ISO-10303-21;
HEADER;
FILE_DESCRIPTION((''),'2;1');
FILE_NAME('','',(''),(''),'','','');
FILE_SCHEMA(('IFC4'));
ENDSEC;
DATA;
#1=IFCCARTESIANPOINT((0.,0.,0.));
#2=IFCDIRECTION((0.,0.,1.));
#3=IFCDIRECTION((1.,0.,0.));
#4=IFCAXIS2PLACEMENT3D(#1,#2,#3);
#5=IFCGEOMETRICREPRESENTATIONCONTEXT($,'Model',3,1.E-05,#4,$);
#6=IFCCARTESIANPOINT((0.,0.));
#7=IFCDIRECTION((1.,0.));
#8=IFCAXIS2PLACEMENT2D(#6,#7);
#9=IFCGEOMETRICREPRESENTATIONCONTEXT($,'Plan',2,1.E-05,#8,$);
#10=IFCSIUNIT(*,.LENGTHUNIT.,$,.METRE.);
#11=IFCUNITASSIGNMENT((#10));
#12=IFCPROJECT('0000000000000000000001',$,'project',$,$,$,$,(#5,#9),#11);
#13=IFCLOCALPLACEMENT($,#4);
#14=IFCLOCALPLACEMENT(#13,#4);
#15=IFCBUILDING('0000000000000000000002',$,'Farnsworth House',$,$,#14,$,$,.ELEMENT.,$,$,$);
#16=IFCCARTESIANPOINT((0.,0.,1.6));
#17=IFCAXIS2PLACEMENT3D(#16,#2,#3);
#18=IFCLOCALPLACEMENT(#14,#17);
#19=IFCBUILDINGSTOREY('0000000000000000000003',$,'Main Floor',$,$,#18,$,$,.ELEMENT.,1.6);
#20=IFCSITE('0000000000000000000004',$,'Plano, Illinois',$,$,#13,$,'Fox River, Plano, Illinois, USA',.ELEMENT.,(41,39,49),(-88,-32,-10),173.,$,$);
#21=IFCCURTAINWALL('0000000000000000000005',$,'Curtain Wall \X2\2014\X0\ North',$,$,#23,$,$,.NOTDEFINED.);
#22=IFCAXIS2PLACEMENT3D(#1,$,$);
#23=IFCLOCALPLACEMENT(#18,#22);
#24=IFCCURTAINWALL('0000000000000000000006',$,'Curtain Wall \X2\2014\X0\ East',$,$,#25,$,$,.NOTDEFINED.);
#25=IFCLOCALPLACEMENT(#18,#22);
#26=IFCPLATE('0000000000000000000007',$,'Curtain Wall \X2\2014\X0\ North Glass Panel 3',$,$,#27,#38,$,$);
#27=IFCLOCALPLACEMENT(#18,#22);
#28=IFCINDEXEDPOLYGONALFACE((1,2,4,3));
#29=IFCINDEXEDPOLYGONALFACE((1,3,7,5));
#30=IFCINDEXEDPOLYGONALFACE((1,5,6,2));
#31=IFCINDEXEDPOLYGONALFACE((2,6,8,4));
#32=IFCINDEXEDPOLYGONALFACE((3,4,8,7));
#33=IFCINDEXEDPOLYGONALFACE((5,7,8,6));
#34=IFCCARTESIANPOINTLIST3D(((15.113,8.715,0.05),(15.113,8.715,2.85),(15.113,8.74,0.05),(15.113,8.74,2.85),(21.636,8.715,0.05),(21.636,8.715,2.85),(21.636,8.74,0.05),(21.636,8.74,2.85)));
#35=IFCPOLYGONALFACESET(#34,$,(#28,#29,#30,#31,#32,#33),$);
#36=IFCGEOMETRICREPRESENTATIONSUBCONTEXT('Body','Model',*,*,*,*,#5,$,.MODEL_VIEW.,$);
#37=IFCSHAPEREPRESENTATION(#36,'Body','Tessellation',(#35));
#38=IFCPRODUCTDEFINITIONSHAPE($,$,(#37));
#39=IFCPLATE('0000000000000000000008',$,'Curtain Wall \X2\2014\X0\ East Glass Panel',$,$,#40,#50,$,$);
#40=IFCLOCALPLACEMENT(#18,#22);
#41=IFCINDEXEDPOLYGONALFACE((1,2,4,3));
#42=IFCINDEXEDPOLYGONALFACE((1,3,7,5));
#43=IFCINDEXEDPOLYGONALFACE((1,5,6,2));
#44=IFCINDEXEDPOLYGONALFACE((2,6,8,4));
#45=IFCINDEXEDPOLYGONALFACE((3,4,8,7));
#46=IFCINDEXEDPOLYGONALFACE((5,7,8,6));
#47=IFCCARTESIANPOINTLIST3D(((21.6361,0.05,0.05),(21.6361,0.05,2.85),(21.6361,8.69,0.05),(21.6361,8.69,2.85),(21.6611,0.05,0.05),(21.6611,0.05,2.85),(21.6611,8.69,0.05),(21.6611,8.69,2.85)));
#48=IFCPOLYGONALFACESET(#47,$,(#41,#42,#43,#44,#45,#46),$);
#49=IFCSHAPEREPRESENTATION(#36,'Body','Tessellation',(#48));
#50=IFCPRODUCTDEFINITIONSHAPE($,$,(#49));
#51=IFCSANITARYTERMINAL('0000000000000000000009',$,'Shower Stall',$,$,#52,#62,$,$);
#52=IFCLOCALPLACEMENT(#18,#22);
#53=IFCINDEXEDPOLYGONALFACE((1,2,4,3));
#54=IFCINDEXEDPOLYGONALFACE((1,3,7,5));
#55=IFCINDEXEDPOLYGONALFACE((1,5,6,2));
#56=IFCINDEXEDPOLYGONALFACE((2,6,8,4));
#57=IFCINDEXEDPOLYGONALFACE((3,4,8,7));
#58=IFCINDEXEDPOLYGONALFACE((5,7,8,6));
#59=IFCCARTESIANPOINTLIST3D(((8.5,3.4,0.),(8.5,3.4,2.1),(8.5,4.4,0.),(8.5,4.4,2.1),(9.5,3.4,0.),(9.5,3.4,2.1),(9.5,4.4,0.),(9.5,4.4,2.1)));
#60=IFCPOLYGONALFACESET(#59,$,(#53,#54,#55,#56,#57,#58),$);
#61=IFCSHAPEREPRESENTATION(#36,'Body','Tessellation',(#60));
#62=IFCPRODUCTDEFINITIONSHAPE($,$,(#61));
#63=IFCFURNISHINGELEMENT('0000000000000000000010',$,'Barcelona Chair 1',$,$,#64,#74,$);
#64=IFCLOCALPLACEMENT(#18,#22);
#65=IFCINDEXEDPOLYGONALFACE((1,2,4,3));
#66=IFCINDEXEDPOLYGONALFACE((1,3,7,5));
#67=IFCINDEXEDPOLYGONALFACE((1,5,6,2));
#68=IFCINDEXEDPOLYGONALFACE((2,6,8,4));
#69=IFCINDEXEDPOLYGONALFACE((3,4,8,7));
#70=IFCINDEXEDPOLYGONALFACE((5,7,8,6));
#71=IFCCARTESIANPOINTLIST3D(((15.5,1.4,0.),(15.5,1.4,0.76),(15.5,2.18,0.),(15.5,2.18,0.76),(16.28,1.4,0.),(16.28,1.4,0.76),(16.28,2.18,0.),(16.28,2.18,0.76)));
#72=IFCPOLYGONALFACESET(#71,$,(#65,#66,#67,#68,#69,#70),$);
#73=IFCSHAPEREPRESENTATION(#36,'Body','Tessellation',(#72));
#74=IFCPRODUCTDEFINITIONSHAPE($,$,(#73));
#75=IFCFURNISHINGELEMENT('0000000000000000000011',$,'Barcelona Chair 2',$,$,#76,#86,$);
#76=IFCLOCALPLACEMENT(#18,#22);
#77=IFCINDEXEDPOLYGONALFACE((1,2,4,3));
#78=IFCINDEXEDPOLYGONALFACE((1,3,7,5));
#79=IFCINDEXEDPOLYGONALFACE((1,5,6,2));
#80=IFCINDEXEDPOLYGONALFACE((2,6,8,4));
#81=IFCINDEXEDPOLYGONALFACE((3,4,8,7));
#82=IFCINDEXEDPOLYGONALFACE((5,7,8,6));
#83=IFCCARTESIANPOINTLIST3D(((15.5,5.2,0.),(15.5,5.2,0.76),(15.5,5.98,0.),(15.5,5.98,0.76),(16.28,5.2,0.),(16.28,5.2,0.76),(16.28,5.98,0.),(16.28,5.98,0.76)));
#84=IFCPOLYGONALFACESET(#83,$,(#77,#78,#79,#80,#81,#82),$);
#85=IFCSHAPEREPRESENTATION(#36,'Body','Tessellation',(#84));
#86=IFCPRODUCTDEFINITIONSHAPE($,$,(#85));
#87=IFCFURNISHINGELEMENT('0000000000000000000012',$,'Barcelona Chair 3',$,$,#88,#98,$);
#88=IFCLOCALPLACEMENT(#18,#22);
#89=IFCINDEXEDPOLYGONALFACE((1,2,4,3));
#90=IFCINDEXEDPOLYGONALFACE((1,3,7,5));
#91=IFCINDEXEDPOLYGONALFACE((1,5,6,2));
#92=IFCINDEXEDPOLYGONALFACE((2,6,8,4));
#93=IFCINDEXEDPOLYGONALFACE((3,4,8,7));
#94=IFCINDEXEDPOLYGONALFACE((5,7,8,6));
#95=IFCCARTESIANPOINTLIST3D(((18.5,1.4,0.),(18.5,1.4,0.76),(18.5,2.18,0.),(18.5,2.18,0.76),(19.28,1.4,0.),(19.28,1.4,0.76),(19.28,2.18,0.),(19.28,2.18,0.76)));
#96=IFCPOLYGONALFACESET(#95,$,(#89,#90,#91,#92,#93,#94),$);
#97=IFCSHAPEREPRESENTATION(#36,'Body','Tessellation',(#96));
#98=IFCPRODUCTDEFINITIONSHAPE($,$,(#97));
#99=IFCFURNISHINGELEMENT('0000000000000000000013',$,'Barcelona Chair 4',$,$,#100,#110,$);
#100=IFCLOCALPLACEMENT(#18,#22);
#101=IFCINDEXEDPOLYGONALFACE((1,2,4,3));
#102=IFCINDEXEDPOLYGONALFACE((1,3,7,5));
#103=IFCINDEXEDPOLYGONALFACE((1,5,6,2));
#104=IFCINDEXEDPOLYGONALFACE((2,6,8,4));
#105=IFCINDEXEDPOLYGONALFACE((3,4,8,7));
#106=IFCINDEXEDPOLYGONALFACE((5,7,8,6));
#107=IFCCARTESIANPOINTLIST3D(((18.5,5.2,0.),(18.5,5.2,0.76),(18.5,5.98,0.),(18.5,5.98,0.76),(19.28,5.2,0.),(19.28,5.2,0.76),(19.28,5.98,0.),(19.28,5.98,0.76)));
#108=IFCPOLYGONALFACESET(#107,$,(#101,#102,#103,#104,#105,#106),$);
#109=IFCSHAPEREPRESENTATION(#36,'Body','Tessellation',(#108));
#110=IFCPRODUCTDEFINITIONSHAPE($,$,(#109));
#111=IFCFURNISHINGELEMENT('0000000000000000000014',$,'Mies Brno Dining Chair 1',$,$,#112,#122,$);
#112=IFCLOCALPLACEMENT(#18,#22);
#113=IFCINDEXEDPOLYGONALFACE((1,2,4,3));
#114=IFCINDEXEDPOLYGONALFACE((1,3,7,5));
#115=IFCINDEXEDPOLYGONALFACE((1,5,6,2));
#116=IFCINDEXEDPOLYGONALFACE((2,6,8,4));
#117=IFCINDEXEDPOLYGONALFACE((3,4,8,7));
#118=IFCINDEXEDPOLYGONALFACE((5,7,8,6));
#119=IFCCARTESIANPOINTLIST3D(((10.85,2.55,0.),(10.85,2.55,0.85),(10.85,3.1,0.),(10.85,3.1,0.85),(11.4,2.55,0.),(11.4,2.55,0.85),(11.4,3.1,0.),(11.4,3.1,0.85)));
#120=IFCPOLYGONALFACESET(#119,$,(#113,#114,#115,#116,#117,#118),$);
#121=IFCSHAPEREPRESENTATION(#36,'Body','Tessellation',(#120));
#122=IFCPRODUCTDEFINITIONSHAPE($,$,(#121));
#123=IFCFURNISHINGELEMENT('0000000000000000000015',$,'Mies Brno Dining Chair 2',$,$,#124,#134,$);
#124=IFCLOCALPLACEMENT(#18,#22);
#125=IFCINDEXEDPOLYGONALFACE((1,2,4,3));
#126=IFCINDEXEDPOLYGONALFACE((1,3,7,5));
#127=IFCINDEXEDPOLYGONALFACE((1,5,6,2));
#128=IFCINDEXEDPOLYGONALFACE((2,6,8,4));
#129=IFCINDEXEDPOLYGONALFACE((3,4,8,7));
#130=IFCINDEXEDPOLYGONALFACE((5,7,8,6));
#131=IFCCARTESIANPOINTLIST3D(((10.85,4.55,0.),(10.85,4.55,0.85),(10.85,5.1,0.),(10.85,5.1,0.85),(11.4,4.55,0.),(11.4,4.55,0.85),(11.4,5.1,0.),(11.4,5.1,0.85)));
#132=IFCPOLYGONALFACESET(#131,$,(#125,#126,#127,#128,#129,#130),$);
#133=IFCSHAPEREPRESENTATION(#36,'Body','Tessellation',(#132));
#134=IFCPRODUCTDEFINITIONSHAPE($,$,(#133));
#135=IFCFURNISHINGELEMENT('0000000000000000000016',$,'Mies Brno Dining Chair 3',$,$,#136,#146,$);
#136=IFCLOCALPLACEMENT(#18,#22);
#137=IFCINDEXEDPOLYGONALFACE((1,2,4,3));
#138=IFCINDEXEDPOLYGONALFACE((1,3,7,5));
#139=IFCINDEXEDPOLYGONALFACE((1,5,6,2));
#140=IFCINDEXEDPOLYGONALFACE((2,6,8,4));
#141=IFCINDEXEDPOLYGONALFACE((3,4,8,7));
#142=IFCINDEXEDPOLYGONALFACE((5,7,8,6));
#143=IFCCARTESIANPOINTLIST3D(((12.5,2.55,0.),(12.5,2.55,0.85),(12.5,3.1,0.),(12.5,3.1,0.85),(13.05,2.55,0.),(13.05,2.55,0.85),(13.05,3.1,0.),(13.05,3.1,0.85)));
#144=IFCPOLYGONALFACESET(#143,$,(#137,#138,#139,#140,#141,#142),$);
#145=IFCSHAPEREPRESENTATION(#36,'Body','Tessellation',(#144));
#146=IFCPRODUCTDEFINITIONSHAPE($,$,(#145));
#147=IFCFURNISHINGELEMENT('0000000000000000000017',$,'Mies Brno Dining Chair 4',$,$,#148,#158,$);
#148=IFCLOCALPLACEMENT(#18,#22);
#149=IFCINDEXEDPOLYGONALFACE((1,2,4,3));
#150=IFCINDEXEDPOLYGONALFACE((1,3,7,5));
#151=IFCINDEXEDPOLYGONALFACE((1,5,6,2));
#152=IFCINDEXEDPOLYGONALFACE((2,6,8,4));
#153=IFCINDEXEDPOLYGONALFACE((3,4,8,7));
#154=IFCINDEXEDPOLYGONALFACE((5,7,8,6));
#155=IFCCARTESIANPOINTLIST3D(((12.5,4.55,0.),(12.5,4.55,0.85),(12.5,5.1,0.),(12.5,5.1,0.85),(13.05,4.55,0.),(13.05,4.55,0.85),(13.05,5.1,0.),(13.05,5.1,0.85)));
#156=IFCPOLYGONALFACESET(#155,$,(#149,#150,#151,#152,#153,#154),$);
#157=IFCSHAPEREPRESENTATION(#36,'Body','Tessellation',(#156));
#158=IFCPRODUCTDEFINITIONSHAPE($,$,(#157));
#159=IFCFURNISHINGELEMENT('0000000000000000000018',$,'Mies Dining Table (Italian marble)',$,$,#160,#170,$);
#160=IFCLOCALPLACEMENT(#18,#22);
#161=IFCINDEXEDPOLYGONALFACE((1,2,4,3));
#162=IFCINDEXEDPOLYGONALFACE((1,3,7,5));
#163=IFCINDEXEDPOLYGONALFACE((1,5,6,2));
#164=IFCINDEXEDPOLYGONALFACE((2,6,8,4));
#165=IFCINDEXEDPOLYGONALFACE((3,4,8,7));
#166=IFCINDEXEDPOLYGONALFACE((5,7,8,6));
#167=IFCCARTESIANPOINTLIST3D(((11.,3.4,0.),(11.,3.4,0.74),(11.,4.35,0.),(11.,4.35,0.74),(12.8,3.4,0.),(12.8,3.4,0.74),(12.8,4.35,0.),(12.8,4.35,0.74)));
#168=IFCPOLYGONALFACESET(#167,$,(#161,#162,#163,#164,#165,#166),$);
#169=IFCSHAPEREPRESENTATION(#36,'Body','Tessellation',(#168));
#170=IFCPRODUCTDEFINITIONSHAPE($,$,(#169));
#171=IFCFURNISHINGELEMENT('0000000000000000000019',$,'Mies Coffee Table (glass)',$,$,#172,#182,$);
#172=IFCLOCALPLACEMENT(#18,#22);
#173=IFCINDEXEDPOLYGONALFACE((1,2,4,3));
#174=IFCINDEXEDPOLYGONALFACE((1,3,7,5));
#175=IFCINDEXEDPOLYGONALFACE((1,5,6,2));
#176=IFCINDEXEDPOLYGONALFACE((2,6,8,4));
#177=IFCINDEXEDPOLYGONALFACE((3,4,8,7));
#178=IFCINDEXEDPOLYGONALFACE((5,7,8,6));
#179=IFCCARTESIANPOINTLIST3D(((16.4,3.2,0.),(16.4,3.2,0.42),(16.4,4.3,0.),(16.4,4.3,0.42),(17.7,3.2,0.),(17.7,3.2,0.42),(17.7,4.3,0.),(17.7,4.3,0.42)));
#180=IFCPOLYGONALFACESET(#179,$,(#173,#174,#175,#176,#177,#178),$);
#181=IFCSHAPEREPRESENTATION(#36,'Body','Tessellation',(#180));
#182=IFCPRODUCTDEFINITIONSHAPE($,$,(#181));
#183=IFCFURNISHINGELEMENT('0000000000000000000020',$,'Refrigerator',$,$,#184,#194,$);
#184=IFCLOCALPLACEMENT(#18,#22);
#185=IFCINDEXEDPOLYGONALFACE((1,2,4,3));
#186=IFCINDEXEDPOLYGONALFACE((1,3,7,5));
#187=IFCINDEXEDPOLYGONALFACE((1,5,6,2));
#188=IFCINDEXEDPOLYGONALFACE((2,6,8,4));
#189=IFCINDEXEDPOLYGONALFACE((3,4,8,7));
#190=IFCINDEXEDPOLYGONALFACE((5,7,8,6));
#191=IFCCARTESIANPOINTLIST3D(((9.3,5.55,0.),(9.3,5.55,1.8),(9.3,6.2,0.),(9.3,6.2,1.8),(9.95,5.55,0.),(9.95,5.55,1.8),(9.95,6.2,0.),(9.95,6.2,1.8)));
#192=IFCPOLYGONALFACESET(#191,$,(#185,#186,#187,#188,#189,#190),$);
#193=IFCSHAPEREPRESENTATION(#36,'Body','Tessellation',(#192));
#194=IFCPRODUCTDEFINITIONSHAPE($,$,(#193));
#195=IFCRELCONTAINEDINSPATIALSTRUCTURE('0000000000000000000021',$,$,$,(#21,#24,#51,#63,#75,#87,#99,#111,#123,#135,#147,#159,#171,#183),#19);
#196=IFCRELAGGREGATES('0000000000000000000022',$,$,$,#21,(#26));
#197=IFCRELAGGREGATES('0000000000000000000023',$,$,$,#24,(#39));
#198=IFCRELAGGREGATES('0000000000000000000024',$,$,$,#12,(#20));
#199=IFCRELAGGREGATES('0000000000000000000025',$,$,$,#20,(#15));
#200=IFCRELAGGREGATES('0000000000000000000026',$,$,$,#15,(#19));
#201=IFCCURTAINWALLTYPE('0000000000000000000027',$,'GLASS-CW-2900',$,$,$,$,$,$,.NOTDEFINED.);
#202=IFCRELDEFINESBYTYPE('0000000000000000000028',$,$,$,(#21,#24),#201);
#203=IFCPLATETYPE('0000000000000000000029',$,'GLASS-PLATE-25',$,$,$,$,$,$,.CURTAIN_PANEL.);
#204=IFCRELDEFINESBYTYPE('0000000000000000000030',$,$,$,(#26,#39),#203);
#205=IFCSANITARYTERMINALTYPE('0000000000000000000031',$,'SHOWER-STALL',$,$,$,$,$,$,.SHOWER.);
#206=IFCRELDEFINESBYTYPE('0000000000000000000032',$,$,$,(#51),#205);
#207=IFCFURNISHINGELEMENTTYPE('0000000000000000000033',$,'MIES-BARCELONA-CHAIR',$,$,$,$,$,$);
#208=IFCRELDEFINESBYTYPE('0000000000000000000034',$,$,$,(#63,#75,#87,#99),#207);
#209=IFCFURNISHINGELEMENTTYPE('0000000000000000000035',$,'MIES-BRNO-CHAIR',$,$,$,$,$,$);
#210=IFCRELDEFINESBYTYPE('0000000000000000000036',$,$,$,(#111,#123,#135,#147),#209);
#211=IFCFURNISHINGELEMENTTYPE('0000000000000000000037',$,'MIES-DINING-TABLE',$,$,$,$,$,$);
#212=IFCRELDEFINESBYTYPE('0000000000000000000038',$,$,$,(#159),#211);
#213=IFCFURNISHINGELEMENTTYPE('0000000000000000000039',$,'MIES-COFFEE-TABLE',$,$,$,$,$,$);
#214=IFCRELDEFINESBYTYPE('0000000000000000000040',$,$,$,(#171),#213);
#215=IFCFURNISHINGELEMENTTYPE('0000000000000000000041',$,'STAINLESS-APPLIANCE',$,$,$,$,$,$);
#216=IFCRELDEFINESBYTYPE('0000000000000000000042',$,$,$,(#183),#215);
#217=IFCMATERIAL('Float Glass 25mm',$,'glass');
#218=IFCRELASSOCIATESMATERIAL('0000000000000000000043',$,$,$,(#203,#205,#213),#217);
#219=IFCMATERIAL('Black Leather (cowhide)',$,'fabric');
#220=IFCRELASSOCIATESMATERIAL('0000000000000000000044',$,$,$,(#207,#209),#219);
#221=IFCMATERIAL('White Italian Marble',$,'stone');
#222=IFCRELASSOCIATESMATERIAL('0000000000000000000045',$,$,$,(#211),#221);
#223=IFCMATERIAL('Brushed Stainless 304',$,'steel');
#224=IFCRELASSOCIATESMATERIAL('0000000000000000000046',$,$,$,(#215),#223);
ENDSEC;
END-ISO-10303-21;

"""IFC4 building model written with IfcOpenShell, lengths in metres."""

from ifc_helpers import new_model, si_unit, frame, origin_with_axes, origin_2d_with_axis, place, context, subcontext, project, spatial, rectangle, extrude, material, type_object, element, aggregate, save


model = new_model("IFC4")

# Units and contexts
model_context = context("Model", 3, precision=1e-05, world=origin_with_axes())
plan_context = context("Plan", 2, precision=1e-05, world=origin_2d_with_axis())
body_context = subcontext(model_context, "Body", "Model", "MODEL_VIEW")
ifc_project = project(units=[si_unit("LENGTHUNIT", "METRE")], contexts=[model_context, plan_context])

# Site, building, storey
site_placement = place(None, origin_with_axes())
site = spatial("IfcSite", under=ifc_project, at=site_placement, Name="Plano, Illinois", LongName="Fox River, Plano, Illinois, USA", CompositionType="ELEMENT", RefLatitude=(41, 39, 49), RefLongitude=(-88, -32, -10), RefElevation=173.0)
building_placement = place(site_placement, origin_with_axes())
building = spatial("IfcBuilding", under=site, at=building_placement, Name="Farnsworth House", CompositionType="ELEMENT")
storey_placement = place(building_placement, frame((0.0, 0.0, 1.6), z_axis=(0.0, 0.0, 1.0), x_axis=(1.0, 0.0, 0.0)))
storey = spatial("IfcBuildingStorey", under=building, at=storey_placement, Name="Main Floor", CompositionType="ELEMENT", Elevation=1.6)

# Curtain walls
curtain_wall_type = type_object("IfcCurtainWallType", Name="GLASS-CW-2900", PredefinedType="NOTDEFINED")
curtain_wall_1_placement = place(storey_placement, frame((1.7839, 8.715, 0.0), z_axis=(0.0, 0.0, 1.0), x_axis=(1.0, 0.0, 0.0)))
curtain_wall_1 = element("IfcCurtainWall", 1, at=curtain_wall_1_placement, inside=storey, type_object=curtain_wall_type, Name="Curtain Wall — North", PredefinedType="NOTDEFINED")
curtain_wall_2_placement = place(storey_placement, frame((21.6611, 0.0, 0.0), z_axis=(0.0, 0.0, 1.0), x_axis=(0.0, 1.0, 0.0)))
curtain_wall_2 = element("IfcCurtainWall", 2, at=curtain_wall_2_placement, inside=storey, type_object=curtain_wall_type, Name="Curtain Wall — East", PredefinedType="NOTDEFINED")

# Shared definitions
ifc_material_1 = material(Name="Float Glass 25mm", Category="glass")
plate_type = type_object("IfcPlateType", Name="GLASS-PLATE-25", PredefinedType="CURTAIN_PANEL", material=ifc_material_1)

# Plates
plate_1_placement = place(curtain_wall_1_placement, frame((13.329, 0.0, 0.05), z_axis=(0.0, 0.0, 1.0), x_axis=(1.0, 0.0, 0.0)))
plate_1 = element("IfcPlate", 3, at=plate_1_placement, type_object=plate_type, Name="Curtain Wall — North Glass Panel 3", context=body_context, shape_type="SweptSolid", body=[
    extrude(rectangle(XDim=6.523, YDim=0.025, at=origin_2d_with_axis()), frame((3.2615, 0.0125, 0.0), z_axis=(0.0, 0.0, 1.0), x_axis=(1.0, 0.0, 0.0)), (0.0, 0.0, 1.0), 2.8),
])
aggregate(curtain_wall_1, [plate_1])
plate_2_placement = place(curtain_wall_2_placement, frame((0.05, 0.0, 0.05), z_axis=(0.0, 0.0, 1.0), x_axis=(1.0, 0.0, 0.0)))
plate_2 = element("IfcPlate", 4, at=plate_2_placement, type_object=plate_type, Name="Curtain Wall — East Glass Panel", context=body_context, shape_type="SweptSolid", body=[
    extrude(rectangle(XDim=8.64, YDim=0.025, at=origin_2d_with_axis()), frame((4.32, 0.0125, 0.0), z_axis=(0.0, 0.0, 1.0), x_axis=(1.0, 0.0, 0.0)), (0.0, 0.0, 1.0), 2.8),
])
aggregate(curtain_wall_2, [plate_2])

# Sanitary terminal
sanitary_terminal_type = type_object("IfcSanitaryTerminalType", Name="SHOWER-STALL", PredefinedType="SHOWER", material=ifc_material_1)
sanitary_terminal_placement = place(storey_placement, frame((8.5, 3.4, 0.0), z_axis=(0.0, 0.0, 1.0), x_axis=(1.0, 0.0, 0.0)))
element("IfcSanitaryTerminal", 5, at=sanitary_terminal_placement, inside=storey, type_object=sanitary_terminal_type, Name="Shower Stall", context=body_context, shape_type="SweptSolid", body=[
    extrude(rectangle(XDim=1.0, YDim=1.0, at=origin_2d_with_axis()), frame((0.5, 0.5, 0.0), z_axis=(0.0, 0.0, 1.0), x_axis=(1.0, 0.0, 0.0)), (0.0, 0.0, 1.0), 2.1),
])

# Furnishing elements
ifc_material_2 = material(Name="Black Leather (cowhide)", Category="fabric")
furnishing_element_type_1 = type_object("IfcFurnishingElementType", Name="MIES-BARCELONA-CHAIR", material=ifc_material_2)
for number, where, z_axis, x_axis, name in (
    (6, (15.5, 1.4, 0.0), (0.0, 0.0, 1.0), (1.0, 0.0, 0.0), "Barcelona Chair 1"),
    (7, (15.5, 5.2, 0.0), (0.0, 0.0, 1.0), (1.0, 0.0, 0.0), "Barcelona Chair 2"),
    (8, (18.5, 1.4, 0.0), (0.0, 0.0, 1.0), (1.0, 0.0, 0.0), "Barcelona Chair 3"),
    (9, (18.5, 5.2, 0.0), (0.0, 0.0, 1.0), (1.0, 0.0, 0.0), "Barcelona Chair 4"),
):
    element("IfcFurnishingElement", number, at=place(storey_placement, frame(where, z_axis=z_axis, x_axis=x_axis)), inside=storey, type_object=furnishing_element_type_1, Name=name, context=body_context, shape_type="SweptSolid", body=[
        extrude(rectangle(XDim=0.78, YDim=0.78, at=origin_2d_with_axis()), frame((0.39, 0.39, 0.0), z_axis=(0.0, 0.0, 1.0), x_axis=(1.0, 0.0, 0.0)), (0.0, 0.0, 1.0), 0.76),
    ])
furnishing_element_type_2 = type_object("IfcFurnishingElementType", Name="MIES-BRNO-CHAIR", material=ifc_material_2)
for number, where, z_axis, x_axis, name in (
    (10, (10.85, 2.55, 0.0), (0.0, 0.0, 1.0), (1.0, 0.0, 0.0), "Mies Brno Dining Chair 1"),
    (11, (10.85, 4.55, 0.0), (0.0, 0.0, 1.0), (1.0, 0.0, 0.0), "Mies Brno Dining Chair 2"),
    (12, (12.5, 2.55, 0.0), (0.0, 0.0, 1.0), (1.0, 0.0, 0.0), "Mies Brno Dining Chair 3"),
    (13, (12.5, 4.55, 0.0), (0.0, 0.0, 1.0), (1.0, 0.0, 0.0), "Mies Brno Dining Chair 4"),
):
    element("IfcFurnishingElement", number, at=place(storey_placement, frame(where, z_axis=z_axis, x_axis=x_axis)), inside=storey, type_object=furnishing_element_type_2, Name=name, context=body_context, shape_type="SweptSolid", body=[
        extrude(rectangle(XDim=0.55, YDim=0.55, at=origin_2d_with_axis()), frame((0.275, 0.275, 0.0), z_axis=(0.0, 0.0, 1.0), x_axis=(1.0, 0.0, 0.0)), (0.0, 0.0, 1.0), 0.85),
    ])
ifc_material_3 = material(Name="White Italian Marble", Category="stone")
furnishing_element_type_3 = type_object("IfcFurnishingElementType", Name="MIES-DINING-TABLE", material=ifc_material_3)
furnishing_1_placement = place(storey_placement, frame((11.0, 3.4, 0.0), z_axis=(0.0, 0.0, 1.0), x_axis=(1.0, 0.0, 0.0)))
element("IfcFurnishingElement", 14, at=furnishing_1_placement, inside=storey, type_object=furnishing_element_type_3, Name="Mies Dining Table (Italian marble)", context=body_context, shape_type="SweptSolid", body=[
    extrude(rectangle(XDim=1.8, YDim=0.95, at=origin_2d_with_axis()), frame((0.9, 0.475, 0.0), z_axis=(0.0, 0.0, 1.0), x_axis=(1.0, 0.0, 0.0)), (0.0, 0.0, 1.0), 0.74),
])
furnishing_element_type_4 = type_object("IfcFurnishingElementType", Name="MIES-COFFEE-TABLE", material=ifc_material_1)
furnishing_2_placement = place(storey_placement, frame((16.4, 3.2, 0.0), z_axis=(0.0, 0.0, 1.0), x_axis=(1.0, 0.0, 0.0)))
element("IfcFurnishingElement", 15, at=furnishing_2_placement, inside=storey, type_object=furnishing_element_type_4, Name="Mies Coffee Table (glass)", context=body_context, shape_type="SweptSolid", body=[
    extrude(rectangle(XDim=1.3, YDim=1.1, at=origin_2d_with_axis()), frame((0.65, 0.55, 0.0), z_axis=(0.0, 0.0, 1.0), x_axis=(1.0, 0.0, 0.0)), (0.0, 0.0, 1.0), 0.42),
])
ifc_material_4 = material(Name="Brushed Stainless 304", Category="steel")
furnishing_element_type_5 = type_object("IfcFurnishingElementType", Name="STAINLESS-APPLIANCE", material=ifc_material_4)
furnishing_3_placement = place(storey_placement, frame((9.3, 5.55, 0.0), z_axis=(0.0, 0.0, 1.0), x_axis=(1.0, 0.0, 0.0)))
element("IfcFurnishingElement", 16, at=furnishing_3_placement, inside=storey, type_object=furnishing_element_type_5, Name="Refrigerator", context=body_context, shape_type="SweptSolid", body=[
    extrude(rectangle(XDim=0.65, YDim=0.65, at=origin_2d_with_axis()), frame((0.325, 0.325, 0.0), z_axis=(0.0, 0.0, 1.0), x_axis=(1.0, 0.0, 0.0)), (0.0, 0.0, 1.0), 1.8),
])

save(model, "model.ifc")
